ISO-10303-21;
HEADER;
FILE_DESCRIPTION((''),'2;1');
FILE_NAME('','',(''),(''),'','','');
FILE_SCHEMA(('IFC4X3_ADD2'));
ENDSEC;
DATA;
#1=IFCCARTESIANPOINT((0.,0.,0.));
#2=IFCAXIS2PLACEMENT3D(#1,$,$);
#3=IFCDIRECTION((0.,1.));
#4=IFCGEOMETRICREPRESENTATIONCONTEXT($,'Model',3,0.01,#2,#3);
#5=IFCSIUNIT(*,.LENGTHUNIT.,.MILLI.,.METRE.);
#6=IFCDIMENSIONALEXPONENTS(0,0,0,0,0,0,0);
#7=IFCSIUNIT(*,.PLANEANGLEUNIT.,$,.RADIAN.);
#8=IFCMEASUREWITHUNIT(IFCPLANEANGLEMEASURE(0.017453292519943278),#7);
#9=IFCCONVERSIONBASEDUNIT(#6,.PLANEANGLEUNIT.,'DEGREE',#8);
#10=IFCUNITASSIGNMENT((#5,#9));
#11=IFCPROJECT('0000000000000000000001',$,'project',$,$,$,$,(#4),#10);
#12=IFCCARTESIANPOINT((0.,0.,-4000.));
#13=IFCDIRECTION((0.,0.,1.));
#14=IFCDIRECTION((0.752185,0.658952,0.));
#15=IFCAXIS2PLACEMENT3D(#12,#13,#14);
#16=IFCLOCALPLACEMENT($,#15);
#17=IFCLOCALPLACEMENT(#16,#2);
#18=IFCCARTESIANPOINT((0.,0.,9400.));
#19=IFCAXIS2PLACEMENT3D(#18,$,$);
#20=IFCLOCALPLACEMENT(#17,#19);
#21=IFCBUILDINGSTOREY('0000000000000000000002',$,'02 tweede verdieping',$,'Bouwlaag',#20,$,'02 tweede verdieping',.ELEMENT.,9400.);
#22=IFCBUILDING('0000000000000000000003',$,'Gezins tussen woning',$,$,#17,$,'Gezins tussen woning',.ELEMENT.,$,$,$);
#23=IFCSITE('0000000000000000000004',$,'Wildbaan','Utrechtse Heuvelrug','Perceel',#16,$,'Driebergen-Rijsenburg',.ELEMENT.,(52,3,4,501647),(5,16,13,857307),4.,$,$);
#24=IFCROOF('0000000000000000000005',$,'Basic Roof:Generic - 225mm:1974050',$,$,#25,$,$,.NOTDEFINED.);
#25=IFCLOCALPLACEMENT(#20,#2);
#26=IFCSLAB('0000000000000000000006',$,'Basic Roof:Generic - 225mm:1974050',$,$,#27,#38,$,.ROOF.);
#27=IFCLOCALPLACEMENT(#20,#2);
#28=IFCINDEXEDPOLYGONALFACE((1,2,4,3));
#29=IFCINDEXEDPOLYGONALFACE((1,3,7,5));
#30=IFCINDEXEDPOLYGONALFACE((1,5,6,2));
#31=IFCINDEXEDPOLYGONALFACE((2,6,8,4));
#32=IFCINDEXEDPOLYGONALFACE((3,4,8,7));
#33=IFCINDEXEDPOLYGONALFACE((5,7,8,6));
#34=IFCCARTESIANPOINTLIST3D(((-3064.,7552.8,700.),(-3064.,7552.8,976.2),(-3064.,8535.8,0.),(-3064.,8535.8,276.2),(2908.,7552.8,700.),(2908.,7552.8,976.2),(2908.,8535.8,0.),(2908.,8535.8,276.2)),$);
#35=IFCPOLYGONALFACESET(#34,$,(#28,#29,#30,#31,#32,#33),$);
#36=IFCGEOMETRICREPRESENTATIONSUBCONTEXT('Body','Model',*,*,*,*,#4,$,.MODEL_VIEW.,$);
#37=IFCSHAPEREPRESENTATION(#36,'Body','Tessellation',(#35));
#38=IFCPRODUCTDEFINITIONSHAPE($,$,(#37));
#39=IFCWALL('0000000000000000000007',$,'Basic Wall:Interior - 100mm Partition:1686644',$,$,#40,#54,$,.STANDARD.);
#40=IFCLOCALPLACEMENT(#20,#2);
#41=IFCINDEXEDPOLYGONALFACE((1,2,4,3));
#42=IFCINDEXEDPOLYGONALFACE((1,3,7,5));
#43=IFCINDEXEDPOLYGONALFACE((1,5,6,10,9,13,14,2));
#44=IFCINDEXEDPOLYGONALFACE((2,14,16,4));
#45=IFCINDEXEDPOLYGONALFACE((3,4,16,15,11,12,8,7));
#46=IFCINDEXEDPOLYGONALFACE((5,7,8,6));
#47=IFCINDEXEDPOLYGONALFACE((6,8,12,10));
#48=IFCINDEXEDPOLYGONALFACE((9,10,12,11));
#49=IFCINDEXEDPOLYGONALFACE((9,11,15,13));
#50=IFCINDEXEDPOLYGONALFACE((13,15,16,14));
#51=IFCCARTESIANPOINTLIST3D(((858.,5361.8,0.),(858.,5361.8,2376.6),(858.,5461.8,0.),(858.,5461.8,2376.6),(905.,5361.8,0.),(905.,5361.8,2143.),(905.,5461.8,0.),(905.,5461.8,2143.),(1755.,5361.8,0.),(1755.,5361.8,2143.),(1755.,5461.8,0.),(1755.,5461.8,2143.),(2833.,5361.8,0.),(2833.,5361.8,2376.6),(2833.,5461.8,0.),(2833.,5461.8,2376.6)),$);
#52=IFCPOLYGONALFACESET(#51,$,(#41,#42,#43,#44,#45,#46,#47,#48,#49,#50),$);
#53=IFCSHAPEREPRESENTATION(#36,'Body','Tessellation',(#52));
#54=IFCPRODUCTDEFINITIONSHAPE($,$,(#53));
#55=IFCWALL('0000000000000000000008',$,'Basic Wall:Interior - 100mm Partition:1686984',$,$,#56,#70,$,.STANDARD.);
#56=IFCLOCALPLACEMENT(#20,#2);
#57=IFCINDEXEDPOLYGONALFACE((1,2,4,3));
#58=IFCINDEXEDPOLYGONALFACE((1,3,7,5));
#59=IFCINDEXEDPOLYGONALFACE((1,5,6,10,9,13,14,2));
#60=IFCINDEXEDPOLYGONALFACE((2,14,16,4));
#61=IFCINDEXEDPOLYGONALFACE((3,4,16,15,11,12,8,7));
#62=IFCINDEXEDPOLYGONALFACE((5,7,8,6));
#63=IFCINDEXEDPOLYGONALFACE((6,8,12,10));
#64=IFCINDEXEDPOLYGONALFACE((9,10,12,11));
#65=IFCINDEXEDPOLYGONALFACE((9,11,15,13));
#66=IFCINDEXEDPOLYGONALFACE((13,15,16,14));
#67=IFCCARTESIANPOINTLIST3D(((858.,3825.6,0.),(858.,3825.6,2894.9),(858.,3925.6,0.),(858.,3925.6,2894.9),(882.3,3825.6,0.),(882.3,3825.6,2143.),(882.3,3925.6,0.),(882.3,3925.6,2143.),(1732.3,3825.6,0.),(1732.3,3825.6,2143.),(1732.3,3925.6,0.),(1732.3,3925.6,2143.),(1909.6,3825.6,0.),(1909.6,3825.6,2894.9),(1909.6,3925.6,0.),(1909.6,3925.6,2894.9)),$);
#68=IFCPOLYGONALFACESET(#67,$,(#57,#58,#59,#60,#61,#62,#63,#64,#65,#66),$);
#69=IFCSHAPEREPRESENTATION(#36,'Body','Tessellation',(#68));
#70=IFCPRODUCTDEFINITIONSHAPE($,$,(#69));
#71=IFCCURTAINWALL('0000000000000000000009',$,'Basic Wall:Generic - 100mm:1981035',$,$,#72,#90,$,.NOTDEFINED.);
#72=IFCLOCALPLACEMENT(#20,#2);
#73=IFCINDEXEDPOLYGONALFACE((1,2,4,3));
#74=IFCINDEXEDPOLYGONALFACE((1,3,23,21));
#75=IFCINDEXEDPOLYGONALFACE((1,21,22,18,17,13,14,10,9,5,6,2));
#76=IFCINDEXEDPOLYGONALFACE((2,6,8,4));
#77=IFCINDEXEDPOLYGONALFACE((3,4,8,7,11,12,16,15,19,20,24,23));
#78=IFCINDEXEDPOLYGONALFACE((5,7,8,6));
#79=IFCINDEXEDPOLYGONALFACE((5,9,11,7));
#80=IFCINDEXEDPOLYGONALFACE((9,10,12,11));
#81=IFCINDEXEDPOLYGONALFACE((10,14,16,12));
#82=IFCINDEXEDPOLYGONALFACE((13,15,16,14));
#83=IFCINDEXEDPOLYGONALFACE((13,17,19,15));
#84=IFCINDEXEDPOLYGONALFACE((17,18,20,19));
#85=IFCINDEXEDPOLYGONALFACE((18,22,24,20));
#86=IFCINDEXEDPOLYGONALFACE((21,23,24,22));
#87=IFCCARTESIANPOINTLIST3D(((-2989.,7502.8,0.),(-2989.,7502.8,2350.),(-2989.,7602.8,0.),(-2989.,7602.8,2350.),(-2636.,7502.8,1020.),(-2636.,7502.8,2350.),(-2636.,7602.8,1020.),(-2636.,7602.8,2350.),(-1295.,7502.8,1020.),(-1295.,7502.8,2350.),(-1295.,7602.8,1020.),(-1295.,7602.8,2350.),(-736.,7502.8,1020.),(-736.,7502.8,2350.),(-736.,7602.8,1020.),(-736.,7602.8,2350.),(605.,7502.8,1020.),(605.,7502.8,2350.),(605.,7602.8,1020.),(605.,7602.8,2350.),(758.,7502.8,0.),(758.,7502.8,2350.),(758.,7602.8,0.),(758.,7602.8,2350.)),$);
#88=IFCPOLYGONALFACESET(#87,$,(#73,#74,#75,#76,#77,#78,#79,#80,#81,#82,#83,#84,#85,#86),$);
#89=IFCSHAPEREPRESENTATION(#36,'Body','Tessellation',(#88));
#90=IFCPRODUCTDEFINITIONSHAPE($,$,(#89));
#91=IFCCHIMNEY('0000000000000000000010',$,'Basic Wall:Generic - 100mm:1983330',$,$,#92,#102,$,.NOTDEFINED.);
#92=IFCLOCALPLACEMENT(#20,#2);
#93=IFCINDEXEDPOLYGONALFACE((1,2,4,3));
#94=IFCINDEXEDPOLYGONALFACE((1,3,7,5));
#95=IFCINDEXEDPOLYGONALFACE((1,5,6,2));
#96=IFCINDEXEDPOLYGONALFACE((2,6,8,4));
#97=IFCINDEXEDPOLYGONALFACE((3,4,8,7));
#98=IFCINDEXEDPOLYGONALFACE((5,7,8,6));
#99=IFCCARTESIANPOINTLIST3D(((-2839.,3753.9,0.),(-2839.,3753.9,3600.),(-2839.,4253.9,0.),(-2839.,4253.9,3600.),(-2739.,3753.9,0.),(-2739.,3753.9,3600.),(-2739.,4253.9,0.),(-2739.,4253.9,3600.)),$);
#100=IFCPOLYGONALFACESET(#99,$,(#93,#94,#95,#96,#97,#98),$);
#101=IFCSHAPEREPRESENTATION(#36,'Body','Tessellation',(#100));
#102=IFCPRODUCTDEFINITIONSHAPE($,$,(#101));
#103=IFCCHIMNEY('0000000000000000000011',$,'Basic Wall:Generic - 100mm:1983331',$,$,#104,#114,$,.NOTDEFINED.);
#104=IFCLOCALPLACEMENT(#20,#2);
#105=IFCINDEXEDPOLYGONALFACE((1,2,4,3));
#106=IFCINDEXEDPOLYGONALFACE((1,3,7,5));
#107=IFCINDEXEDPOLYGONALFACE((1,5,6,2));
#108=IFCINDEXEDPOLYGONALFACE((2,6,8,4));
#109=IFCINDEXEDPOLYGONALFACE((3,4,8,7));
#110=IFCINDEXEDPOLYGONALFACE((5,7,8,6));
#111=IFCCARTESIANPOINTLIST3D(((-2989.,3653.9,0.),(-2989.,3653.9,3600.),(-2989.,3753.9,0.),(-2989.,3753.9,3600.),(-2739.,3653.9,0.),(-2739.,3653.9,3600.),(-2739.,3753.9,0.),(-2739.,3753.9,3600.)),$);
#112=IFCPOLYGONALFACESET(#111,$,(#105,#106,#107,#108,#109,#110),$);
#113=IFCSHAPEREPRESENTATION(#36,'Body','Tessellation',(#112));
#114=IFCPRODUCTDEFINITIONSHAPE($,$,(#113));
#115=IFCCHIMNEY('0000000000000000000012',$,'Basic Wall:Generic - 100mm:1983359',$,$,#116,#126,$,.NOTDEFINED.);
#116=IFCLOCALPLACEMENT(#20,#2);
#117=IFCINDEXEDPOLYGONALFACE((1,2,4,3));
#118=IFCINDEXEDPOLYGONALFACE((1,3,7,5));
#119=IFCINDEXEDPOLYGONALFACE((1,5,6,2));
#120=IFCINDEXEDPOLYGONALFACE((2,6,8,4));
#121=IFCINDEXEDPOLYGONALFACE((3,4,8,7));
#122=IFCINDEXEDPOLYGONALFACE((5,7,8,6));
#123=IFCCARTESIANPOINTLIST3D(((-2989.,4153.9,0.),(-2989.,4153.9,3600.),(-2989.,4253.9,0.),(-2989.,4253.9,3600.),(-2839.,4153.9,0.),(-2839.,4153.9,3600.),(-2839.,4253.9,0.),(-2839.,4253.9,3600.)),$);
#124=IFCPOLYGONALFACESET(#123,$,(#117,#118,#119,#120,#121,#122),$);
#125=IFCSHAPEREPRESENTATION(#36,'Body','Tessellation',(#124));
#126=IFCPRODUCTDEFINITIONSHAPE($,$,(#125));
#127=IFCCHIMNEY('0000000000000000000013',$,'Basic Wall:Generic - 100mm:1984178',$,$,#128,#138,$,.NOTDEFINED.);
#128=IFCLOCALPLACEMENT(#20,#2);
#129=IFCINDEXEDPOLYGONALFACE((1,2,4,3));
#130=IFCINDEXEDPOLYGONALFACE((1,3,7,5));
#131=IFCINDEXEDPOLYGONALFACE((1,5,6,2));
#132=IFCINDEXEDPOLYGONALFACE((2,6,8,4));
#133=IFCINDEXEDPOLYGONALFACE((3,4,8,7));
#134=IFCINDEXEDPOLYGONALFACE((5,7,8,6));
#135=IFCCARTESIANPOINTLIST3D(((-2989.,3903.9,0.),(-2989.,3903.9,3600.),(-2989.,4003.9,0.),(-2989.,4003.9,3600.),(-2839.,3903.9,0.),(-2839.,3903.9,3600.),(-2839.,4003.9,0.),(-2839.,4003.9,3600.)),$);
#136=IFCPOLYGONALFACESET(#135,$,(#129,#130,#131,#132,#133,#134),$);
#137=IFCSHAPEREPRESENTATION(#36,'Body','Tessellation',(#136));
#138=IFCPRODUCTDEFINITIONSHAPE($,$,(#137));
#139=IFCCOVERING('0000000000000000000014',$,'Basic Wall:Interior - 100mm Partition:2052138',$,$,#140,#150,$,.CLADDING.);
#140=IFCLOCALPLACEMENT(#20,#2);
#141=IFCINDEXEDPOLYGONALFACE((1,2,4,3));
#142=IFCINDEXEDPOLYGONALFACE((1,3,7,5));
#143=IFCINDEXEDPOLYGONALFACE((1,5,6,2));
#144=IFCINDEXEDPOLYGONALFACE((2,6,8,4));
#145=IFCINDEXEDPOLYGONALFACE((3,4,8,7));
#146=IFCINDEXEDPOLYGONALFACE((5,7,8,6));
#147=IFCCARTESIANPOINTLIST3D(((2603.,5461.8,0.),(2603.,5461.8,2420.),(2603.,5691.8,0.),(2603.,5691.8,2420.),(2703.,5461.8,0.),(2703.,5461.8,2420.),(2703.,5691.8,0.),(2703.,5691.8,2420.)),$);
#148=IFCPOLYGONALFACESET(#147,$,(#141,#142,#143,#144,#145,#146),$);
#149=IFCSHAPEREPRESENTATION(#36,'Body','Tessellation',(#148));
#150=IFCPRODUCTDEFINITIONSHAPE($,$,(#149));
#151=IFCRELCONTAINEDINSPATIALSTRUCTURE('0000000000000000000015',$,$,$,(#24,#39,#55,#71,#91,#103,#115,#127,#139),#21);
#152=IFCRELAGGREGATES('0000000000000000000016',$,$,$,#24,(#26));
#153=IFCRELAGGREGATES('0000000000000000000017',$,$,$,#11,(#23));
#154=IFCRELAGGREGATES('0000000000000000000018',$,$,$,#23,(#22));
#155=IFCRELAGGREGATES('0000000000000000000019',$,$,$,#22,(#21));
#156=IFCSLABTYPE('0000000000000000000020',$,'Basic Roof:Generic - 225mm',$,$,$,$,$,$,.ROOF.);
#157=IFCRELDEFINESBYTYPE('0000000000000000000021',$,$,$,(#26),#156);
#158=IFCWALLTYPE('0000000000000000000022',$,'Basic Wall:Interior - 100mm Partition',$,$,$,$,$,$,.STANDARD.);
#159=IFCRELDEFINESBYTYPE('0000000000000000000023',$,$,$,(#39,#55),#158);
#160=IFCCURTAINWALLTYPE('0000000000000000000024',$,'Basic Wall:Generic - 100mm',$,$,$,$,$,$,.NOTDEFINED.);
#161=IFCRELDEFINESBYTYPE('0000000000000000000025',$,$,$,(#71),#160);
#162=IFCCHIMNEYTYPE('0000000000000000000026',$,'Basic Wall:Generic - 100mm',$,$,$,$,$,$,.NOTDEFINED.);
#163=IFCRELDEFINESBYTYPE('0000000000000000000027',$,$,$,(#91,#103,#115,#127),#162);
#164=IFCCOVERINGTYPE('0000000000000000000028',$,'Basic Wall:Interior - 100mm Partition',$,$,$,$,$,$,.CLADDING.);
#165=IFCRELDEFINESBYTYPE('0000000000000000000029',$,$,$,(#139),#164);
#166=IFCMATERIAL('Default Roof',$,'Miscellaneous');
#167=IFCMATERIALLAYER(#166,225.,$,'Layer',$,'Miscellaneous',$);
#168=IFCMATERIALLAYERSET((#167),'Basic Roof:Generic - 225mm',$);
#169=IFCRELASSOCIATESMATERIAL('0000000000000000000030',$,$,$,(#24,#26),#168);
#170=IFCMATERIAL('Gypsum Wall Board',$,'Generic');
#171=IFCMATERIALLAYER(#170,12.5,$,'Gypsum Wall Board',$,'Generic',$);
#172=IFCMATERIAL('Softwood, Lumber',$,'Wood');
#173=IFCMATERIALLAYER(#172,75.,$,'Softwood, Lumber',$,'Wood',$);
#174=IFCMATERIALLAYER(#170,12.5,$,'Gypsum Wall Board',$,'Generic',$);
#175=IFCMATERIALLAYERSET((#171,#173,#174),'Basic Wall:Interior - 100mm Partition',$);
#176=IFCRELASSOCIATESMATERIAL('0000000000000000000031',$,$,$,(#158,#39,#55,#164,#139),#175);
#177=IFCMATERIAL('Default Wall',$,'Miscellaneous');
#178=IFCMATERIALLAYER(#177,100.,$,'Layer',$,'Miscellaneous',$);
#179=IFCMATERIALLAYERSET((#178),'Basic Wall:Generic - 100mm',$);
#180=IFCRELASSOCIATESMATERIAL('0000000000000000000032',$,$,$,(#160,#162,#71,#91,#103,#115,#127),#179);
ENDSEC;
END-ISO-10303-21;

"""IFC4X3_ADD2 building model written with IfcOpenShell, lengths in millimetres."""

from ifc_helpers import new_model, entity, si_unit, converted_unit, direction, frame, frame_2d, origin, place, context, subcontext, project, spatial, rectangle, extrude, material, layer, layer_set, layer_usage, type_object, element, aggregate, save


model = new_model("IFC4X3_ADD2")

# Units and contexts
model_context = context("Model", 3, precision=0.01, world=origin(), true_north=direction((0.0, 1.0)))
body_context = subcontext(model_context, "Body", "Model", "MODEL_VIEW")
ifc_project = project(units=[si_unit("LENGTHUNIT", "METRE", prefix="MILLI"), converted_unit("PLANEANGLEUNIT", "DEGREE", entity("IfcPlaneAngleMeasure", 0.017453292519943278), si_unit("PLANEANGLEUNIT", "RADIAN"), dimensions=[0, 0, 0, 0, 0, 0, 0])], contexts=[model_context])

# Site, building, storey
site_placement = place(None, frame((0.0, 0.0, -4000.0), z_axis=(0.0, 0.0, 1.0), x_axis=(0.752185, 0.658952, 0.0)))
site = spatial("IfcSite", under=ifc_project, at=site_placement, Name="Wildbaan", Description="Utrechtse Heuvelrug", ObjectType="Perceel", LongName="Driebergen-Rijsenburg", CompositionType="ELEMENT", RefLatitude=(52, 3, 4, 501647), RefLongitude=(5, 16, 13, 857307), RefElevation=4.0)
building_placement = place(site_placement, origin())
building = spatial("IfcBuilding", under=site, at=building_placement, Name="Gezins tussen woning", LongName="Gezins tussen woning", CompositionType="ELEMENT")
storey_placement = place(building_placement, frame((0.0, 0.0, 9400.0)))
storey = spatial("IfcBuildingStorey", under=building, at=storey_placement, Name="02 tweede verdieping", ObjectType="Bouwlaag", LongName="02 tweede verdieping", CompositionType="ELEMENT", Elevation=9400.0)

# Roof, slab
ifc_material_1 = material(Name="Default Roof", Category="Miscellaneous")
ifc_layer_1 = layer(ifc_material_1, 225.0, Name="Layer", Category="Miscellaneous")
ifc_layer_set_1 = layer_set([ifc_layer_1], Name="Basic Roof:Generic - 225mm")
roof_placement = place(storey_placement, frame((-3064.0, 7552.8, 0.0)))
roof = element("IfcRoof", 1, at=roof_placement, inside=storey, material=ifc_layer_set_1, Name="Basic Roof:Generic - 225mm:1974050", PredefinedType="NOTDEFINED")
slab_type = type_object("IfcSlabType", Name="Basic Roof:Generic - 225mm", PredefinedType="ROOF")
slab_placement = place(roof_placement, origin())
slab = element("IfcSlab", 2, at=slab_placement, type_object=slab_type, material=ifc_layer_set_1, Name="Basic Roof:Generic - 225mm:1974050", PredefinedType="ROOF", context=body_context, shape_type="SweptSolid", body=[
    extrude(rectangle(XDim=1206.8, YDim=5972.0, at=frame_2d((0.0, 0.0), x_axis=(0.0, -1.0))), frame((2986.0, 491.5, 350.0), z_axis=(0.0, 0.580062, 0.814572), x_axis=(1.0, 0.0, 0.0)), (0.0, -0.580062, 0.814572), 276.2),
])
aggregate(roof, [slab])

# Walls, openings
ifc_material_2 = material(Name="Gypsum Wall Board", Category="Generic")
ifc_layer_2 = layer(ifc_material_2, 12.5, Name="Gypsum Wall Board", Category="Generic")
ifc_material_3 = material(Name="Softwood, Lumber", Category="Wood")
ifc_layer_3 = layer(ifc_material_3, 75.0, Name="Softwood, Lumber", Category="Wood")
ifc_layer_4 = layer(ifc_material_2, 12.5, Name="Gypsum Wall Board", Category="Generic")
ifc_layer_set_2 = layer_set([ifc_layer_2, ifc_layer_3, ifc_layer_4], Name="Basic Wall:Interior - 100mm Partition")
wall_type_1 = type_object("IfcWallType", Name="Basic Wall:Interior - 100mm Partition", PredefinedType="STANDARD", material=ifc_layer_set_2)
wall_1_placement = place(storey_placement, frame((2833.0, 5411.8, 0.0), z_axis=(0.0, 0.0, 1.0), x_axis=(-1.0, 0.0, 0.0)))
wall_1 = element("IfcWall", 3, at=wall_1_placement, inside=storey, type_object=wall_type_1, material=ifc_layer_set_2, Name="Basic Wall:Interior - 100mm Partition:1686644", PredefinedType="STANDARD", context=body_context, shape_type="SweptSolid", body=[
    extrude(rectangle(XDim=1975.0, YDim=100.0, at=frame_2d((987.5, 0.0), x_axis=(-1.0, 0.0))), origin(), (0.0, 0.0, 1.0), 2376.6),
])
opening_1_placement = place(wall_1_placement, frame((2833.0, 5411.8, -2.0), z_axis=(0.0, 0.0, 1.0), x_axis=(-1.0, 0.0, 0.0)))
element("IfcOpeningElement", 4, at=opening_1_placement, cuts=wall_1, PredefinedType="OPENING", context=body_context, shape_type="SweptSolid", body=[
    extrude(rectangle(XDim=2145.0, YDim=850.0, at=frame_2d((0.0, 0.0), x_axis=(0.0, 1.0))), frame((1330.0, 5461.8, 1072.5), z_axis=(0.0, -1.0, 0.0), x_axis=(-1.0, 0.0, 0.0)), (0.0, 0.0, 1.0), 100.0),
])
wall_2_placement = place(storey_placement, frame((858.0, 3875.6, 0.0)))
wall_2 = element("IfcWall", 5, at=wall_2_placement, inside=storey, type_object=wall_type_1, material=ifc_layer_set_2, Name="Basic Wall:Interior - 100mm Partition:1686984", PredefinedType="STANDARD", context=body_context, shape_type="SweptSolid", body=[
    extrude(rectangle(XDim=1051.6, YDim=100.0, at=frame_2d((525.8, 0.0), x_axis=(1.0, 0.0))), origin(), (0.0, 0.0, 1.0), 2894.9),
])
opening_2_placement = place(wall_2_placement, frame((-858.0, -3875.6, -2.0)))
element("IfcOpeningElement", 6, at=opening_2_placement, cuts=wall_2, PredefinedType="OPENING", context=body_context, shape_type="SweptSolid", body=[
    extrude(rectangle(XDim=2145.0, YDim=850.0, at=frame_2d((0.0, 0.0), x_axis=(1.0, 0.0))), frame((1307.3, 3825.6, 1072.5), z_axis=(0.0, 1.0, 0.0), x_axis=(0.0, 0.0, -1.0)), (0.0, 0.0, 1.0), 100.0),
])

# Shared definitions
ifc_material_4 = material(Name="Default Wall", Category="Miscellaneous")

# Curtain wall, openings
ifc_layer_5 = layer(ifc_material_4, 100.0, Name="Layer", Category="Miscellaneous")
ifc_layer_set_3 = layer_set([ifc_layer_5], Name="Basic Wall:Generic - 100mm")
ifc_layer_usage_1 = layer_usage(ifc_layer_set_3, "AXIS2", "POSITIVE", -50.0)
curtain_wall_type = type_object("IfcCurtainWallType", Name="Basic Wall:Generic - 100mm", PredefinedType="NOTDEFINED", material=ifc_layer_set_3)
curtain_wall_placement = place(storey_placement, frame((-2989.0, 7552.8, 0.0)))
curtain_wall = element("IfcCurtainWall", 7, at=curtain_wall_placement, inside=storey, type_object=curtain_wall_type, material=ifc_layer_usage_1, Name="Basic Wall:Generic - 100mm:1981035", PredefinedType="NOTDEFINED", context=body_context, shape_type="SweptSolid", body=[
    extrude(rectangle(XDim=3747.0, YDim=100.0, at=frame_2d((1873.5, 0.0), x_axis=(-1.0, 0.0))), origin(), (0.0, 0.0, 1.0), 2350.0),
])
opening_3_placement = place(curtain_wall_placement, frame((2989.0, -7552.8, 1020.0)))
element("IfcOpeningElement", 8, at=opening_3_placement, cuts=curtain_wall, PredefinedType="OPENING", context=body_context, shape_type="SweptSolid", body=[
    extrude(rectangle(XDim=1330.0, YDim=1341.0, at=frame_2d((0.0, 0.0), x_axis=(0.0, 1.0))), frame((-1965.5, 7502.8, 665.0), z_axis=(0.0, 1.0, 0.0), x_axis=(1.0, 0.0, 0.0)), (0.0, 0.0, 1.0), 100.0),
])
opening_4_placement = place(curtain_wall_placement, frame((2989.0, -7552.8, 1020.0)))
element("IfcOpeningElement", 9, at=opening_4_placement, cuts=curtain_wall, PredefinedType="OPENING", context=body_context, shape_type="SweptSolid", body=[
    extrude(rectangle(XDim=1330.0, YDim=1341.0, at=frame_2d((0.0, 0.0), x_axis=(0.0, 1.0))), frame((-65.5, 7502.8, 665.0), z_axis=(0.0, 1.0, 0.0), x_axis=(1.0, 0.0, 0.0)), (0.0, 0.0, 1.0), 100.0),
])

# Chimneys
ifc_layer_usage_2 = layer_usage(ifc_layer_set_3, "AXIS2", "NEGATIVE", 50.0)
chimney_type = type_object("IfcChimneyType", Name="Basic Wall:Generic - 100mm", PredefinedType="NOTDEFINED", material=ifc_layer_set_3)
chimney_1_placement = place(storey_placement, frame((-2789.0, 4253.9, 0.0), z_axis=(0.0, 0.0, 1.0), x_axis=(0.0, -1.0, 0.0)))
element("IfcChimney", 10, at=chimney_1_placement, inside=storey, type_object=chimney_type, material=ifc_layer_usage_2, Name="Basic Wall:Generic - 100mm:1983330", PredefinedType="NOTDEFINED", context=body_context, shape_type="SweptSolid", body=[
    extrude(rectangle(XDim=500.0, YDim=100.0, at=frame_2d((250.0, 0.0), x_axis=(-1.0, 0.0))), origin(), (0.0, 0.0, 1.0), 3600.0),
])
ifc_layer_usage_3 = layer_usage(ifc_layer_set_3, "AXIS2", "NEGATIVE", 50.0)
chimney_2_placement = place(storey_placement, frame((-2739.0, 3703.9, 0.0), z_axis=(0.0, 0.0, 1.0), x_axis=(-1.0, 0.0, 0.0)))
element("IfcChimney", 11, at=chimney_2_placement, inside=storey, type_object=chimney_type, material=ifc_layer_usage_3, Name="Basic Wall:Generic - 100mm:1983331", PredefinedType="NOTDEFINED", context=body_context, shape_type="SweptSolid", body=[
    extrude(rectangle(XDim=250.0, YDim=100.0, at=frame_2d((125.0, 0.0), x_axis=(-1.0, 0.0))), origin(), (0.0, 0.0, 1.0), 3600.0),
])
ifc_layer_usage_4 = layer_usage(ifc_layer_set_3, "AXIS2", "NEGATIVE", 50.0)
chimney_3_placement = place(storey_placement, frame((-2989.0, 4203.9, 0.0)))
element("IfcChimney", 12, at=chimney_3_placement, inside=storey, type_object=chimney_type, material=ifc_layer_usage_4, Name="Basic Wall:Generic - 100mm:1983359", PredefinedType="NOTDEFINED", context=body_context, shape_type="SweptSolid", body=[
    extrude(rectangle(XDim=150.0, YDim=100.0, at=frame_2d((75.0, 0.0), x_axis=(-1.0, 0.0))), origin(), (0.0, 0.0, 1.0), 3600.0),
])
ifc_layer_usage_5 = layer_usage(ifc_layer_set_3, "AXIS2", "NEGATIVE", 50.0)
chimney_4_placement = place(storey_placement, frame((-2989.0, 3953.9, 0.0)))
element("IfcChimney", 13, at=chimney_4_placement, inside=storey, type_object=chimney_type, material=ifc_layer_usage_5, Name="Basic Wall:Generic - 100mm:1984178", PredefinedType="NOTDEFINED", context=body_context, shape_type="SweptSolid", body=[
    extrude(rectangle(XDim=150.0, YDim=100.0, at=frame_2d((75.0, 0.0), x_axis=(-1.0, 0.0))), origin(), (0.0, 0.0, 1.0), 3600.0),
])

# Covering
ifc_layer_usage_6 = layer_usage(ifc_layer_set_2, "AXIS2", "NEGATIVE", 50.0)
covering_type_1 = type_object("IfcCoveringType", Name="Basic Wall:Interior - 100mm Partition", PredefinedType="CLADDING", material=ifc_layer_set_2)
covering_1_placement = place(storey_placement, frame((2653.0, 5461.8, 0.0), z_axis=(0.0, 0.0, 1.0), x_axis=(0.0, 1.0, 0.0)))
element("IfcCovering", 14, at=covering_1_placement, inside=storey, type_object=covering_type_1, material=ifc_layer_usage_6, Name="Basic Wall:Interior - 100mm Partition:2052138", PredefinedType="CLADDING", context=body_context, shape_type="SweptSolid", body=[
    extrude(rectangle(XDim=230.0, YDim=100.0, at=frame_2d((115.0, 0.0), x_axis=(-1.0, 0.0))), origin(), (0.0, 0.0, 1.0), 2420.0),
])

save(model, "model.ifc")
